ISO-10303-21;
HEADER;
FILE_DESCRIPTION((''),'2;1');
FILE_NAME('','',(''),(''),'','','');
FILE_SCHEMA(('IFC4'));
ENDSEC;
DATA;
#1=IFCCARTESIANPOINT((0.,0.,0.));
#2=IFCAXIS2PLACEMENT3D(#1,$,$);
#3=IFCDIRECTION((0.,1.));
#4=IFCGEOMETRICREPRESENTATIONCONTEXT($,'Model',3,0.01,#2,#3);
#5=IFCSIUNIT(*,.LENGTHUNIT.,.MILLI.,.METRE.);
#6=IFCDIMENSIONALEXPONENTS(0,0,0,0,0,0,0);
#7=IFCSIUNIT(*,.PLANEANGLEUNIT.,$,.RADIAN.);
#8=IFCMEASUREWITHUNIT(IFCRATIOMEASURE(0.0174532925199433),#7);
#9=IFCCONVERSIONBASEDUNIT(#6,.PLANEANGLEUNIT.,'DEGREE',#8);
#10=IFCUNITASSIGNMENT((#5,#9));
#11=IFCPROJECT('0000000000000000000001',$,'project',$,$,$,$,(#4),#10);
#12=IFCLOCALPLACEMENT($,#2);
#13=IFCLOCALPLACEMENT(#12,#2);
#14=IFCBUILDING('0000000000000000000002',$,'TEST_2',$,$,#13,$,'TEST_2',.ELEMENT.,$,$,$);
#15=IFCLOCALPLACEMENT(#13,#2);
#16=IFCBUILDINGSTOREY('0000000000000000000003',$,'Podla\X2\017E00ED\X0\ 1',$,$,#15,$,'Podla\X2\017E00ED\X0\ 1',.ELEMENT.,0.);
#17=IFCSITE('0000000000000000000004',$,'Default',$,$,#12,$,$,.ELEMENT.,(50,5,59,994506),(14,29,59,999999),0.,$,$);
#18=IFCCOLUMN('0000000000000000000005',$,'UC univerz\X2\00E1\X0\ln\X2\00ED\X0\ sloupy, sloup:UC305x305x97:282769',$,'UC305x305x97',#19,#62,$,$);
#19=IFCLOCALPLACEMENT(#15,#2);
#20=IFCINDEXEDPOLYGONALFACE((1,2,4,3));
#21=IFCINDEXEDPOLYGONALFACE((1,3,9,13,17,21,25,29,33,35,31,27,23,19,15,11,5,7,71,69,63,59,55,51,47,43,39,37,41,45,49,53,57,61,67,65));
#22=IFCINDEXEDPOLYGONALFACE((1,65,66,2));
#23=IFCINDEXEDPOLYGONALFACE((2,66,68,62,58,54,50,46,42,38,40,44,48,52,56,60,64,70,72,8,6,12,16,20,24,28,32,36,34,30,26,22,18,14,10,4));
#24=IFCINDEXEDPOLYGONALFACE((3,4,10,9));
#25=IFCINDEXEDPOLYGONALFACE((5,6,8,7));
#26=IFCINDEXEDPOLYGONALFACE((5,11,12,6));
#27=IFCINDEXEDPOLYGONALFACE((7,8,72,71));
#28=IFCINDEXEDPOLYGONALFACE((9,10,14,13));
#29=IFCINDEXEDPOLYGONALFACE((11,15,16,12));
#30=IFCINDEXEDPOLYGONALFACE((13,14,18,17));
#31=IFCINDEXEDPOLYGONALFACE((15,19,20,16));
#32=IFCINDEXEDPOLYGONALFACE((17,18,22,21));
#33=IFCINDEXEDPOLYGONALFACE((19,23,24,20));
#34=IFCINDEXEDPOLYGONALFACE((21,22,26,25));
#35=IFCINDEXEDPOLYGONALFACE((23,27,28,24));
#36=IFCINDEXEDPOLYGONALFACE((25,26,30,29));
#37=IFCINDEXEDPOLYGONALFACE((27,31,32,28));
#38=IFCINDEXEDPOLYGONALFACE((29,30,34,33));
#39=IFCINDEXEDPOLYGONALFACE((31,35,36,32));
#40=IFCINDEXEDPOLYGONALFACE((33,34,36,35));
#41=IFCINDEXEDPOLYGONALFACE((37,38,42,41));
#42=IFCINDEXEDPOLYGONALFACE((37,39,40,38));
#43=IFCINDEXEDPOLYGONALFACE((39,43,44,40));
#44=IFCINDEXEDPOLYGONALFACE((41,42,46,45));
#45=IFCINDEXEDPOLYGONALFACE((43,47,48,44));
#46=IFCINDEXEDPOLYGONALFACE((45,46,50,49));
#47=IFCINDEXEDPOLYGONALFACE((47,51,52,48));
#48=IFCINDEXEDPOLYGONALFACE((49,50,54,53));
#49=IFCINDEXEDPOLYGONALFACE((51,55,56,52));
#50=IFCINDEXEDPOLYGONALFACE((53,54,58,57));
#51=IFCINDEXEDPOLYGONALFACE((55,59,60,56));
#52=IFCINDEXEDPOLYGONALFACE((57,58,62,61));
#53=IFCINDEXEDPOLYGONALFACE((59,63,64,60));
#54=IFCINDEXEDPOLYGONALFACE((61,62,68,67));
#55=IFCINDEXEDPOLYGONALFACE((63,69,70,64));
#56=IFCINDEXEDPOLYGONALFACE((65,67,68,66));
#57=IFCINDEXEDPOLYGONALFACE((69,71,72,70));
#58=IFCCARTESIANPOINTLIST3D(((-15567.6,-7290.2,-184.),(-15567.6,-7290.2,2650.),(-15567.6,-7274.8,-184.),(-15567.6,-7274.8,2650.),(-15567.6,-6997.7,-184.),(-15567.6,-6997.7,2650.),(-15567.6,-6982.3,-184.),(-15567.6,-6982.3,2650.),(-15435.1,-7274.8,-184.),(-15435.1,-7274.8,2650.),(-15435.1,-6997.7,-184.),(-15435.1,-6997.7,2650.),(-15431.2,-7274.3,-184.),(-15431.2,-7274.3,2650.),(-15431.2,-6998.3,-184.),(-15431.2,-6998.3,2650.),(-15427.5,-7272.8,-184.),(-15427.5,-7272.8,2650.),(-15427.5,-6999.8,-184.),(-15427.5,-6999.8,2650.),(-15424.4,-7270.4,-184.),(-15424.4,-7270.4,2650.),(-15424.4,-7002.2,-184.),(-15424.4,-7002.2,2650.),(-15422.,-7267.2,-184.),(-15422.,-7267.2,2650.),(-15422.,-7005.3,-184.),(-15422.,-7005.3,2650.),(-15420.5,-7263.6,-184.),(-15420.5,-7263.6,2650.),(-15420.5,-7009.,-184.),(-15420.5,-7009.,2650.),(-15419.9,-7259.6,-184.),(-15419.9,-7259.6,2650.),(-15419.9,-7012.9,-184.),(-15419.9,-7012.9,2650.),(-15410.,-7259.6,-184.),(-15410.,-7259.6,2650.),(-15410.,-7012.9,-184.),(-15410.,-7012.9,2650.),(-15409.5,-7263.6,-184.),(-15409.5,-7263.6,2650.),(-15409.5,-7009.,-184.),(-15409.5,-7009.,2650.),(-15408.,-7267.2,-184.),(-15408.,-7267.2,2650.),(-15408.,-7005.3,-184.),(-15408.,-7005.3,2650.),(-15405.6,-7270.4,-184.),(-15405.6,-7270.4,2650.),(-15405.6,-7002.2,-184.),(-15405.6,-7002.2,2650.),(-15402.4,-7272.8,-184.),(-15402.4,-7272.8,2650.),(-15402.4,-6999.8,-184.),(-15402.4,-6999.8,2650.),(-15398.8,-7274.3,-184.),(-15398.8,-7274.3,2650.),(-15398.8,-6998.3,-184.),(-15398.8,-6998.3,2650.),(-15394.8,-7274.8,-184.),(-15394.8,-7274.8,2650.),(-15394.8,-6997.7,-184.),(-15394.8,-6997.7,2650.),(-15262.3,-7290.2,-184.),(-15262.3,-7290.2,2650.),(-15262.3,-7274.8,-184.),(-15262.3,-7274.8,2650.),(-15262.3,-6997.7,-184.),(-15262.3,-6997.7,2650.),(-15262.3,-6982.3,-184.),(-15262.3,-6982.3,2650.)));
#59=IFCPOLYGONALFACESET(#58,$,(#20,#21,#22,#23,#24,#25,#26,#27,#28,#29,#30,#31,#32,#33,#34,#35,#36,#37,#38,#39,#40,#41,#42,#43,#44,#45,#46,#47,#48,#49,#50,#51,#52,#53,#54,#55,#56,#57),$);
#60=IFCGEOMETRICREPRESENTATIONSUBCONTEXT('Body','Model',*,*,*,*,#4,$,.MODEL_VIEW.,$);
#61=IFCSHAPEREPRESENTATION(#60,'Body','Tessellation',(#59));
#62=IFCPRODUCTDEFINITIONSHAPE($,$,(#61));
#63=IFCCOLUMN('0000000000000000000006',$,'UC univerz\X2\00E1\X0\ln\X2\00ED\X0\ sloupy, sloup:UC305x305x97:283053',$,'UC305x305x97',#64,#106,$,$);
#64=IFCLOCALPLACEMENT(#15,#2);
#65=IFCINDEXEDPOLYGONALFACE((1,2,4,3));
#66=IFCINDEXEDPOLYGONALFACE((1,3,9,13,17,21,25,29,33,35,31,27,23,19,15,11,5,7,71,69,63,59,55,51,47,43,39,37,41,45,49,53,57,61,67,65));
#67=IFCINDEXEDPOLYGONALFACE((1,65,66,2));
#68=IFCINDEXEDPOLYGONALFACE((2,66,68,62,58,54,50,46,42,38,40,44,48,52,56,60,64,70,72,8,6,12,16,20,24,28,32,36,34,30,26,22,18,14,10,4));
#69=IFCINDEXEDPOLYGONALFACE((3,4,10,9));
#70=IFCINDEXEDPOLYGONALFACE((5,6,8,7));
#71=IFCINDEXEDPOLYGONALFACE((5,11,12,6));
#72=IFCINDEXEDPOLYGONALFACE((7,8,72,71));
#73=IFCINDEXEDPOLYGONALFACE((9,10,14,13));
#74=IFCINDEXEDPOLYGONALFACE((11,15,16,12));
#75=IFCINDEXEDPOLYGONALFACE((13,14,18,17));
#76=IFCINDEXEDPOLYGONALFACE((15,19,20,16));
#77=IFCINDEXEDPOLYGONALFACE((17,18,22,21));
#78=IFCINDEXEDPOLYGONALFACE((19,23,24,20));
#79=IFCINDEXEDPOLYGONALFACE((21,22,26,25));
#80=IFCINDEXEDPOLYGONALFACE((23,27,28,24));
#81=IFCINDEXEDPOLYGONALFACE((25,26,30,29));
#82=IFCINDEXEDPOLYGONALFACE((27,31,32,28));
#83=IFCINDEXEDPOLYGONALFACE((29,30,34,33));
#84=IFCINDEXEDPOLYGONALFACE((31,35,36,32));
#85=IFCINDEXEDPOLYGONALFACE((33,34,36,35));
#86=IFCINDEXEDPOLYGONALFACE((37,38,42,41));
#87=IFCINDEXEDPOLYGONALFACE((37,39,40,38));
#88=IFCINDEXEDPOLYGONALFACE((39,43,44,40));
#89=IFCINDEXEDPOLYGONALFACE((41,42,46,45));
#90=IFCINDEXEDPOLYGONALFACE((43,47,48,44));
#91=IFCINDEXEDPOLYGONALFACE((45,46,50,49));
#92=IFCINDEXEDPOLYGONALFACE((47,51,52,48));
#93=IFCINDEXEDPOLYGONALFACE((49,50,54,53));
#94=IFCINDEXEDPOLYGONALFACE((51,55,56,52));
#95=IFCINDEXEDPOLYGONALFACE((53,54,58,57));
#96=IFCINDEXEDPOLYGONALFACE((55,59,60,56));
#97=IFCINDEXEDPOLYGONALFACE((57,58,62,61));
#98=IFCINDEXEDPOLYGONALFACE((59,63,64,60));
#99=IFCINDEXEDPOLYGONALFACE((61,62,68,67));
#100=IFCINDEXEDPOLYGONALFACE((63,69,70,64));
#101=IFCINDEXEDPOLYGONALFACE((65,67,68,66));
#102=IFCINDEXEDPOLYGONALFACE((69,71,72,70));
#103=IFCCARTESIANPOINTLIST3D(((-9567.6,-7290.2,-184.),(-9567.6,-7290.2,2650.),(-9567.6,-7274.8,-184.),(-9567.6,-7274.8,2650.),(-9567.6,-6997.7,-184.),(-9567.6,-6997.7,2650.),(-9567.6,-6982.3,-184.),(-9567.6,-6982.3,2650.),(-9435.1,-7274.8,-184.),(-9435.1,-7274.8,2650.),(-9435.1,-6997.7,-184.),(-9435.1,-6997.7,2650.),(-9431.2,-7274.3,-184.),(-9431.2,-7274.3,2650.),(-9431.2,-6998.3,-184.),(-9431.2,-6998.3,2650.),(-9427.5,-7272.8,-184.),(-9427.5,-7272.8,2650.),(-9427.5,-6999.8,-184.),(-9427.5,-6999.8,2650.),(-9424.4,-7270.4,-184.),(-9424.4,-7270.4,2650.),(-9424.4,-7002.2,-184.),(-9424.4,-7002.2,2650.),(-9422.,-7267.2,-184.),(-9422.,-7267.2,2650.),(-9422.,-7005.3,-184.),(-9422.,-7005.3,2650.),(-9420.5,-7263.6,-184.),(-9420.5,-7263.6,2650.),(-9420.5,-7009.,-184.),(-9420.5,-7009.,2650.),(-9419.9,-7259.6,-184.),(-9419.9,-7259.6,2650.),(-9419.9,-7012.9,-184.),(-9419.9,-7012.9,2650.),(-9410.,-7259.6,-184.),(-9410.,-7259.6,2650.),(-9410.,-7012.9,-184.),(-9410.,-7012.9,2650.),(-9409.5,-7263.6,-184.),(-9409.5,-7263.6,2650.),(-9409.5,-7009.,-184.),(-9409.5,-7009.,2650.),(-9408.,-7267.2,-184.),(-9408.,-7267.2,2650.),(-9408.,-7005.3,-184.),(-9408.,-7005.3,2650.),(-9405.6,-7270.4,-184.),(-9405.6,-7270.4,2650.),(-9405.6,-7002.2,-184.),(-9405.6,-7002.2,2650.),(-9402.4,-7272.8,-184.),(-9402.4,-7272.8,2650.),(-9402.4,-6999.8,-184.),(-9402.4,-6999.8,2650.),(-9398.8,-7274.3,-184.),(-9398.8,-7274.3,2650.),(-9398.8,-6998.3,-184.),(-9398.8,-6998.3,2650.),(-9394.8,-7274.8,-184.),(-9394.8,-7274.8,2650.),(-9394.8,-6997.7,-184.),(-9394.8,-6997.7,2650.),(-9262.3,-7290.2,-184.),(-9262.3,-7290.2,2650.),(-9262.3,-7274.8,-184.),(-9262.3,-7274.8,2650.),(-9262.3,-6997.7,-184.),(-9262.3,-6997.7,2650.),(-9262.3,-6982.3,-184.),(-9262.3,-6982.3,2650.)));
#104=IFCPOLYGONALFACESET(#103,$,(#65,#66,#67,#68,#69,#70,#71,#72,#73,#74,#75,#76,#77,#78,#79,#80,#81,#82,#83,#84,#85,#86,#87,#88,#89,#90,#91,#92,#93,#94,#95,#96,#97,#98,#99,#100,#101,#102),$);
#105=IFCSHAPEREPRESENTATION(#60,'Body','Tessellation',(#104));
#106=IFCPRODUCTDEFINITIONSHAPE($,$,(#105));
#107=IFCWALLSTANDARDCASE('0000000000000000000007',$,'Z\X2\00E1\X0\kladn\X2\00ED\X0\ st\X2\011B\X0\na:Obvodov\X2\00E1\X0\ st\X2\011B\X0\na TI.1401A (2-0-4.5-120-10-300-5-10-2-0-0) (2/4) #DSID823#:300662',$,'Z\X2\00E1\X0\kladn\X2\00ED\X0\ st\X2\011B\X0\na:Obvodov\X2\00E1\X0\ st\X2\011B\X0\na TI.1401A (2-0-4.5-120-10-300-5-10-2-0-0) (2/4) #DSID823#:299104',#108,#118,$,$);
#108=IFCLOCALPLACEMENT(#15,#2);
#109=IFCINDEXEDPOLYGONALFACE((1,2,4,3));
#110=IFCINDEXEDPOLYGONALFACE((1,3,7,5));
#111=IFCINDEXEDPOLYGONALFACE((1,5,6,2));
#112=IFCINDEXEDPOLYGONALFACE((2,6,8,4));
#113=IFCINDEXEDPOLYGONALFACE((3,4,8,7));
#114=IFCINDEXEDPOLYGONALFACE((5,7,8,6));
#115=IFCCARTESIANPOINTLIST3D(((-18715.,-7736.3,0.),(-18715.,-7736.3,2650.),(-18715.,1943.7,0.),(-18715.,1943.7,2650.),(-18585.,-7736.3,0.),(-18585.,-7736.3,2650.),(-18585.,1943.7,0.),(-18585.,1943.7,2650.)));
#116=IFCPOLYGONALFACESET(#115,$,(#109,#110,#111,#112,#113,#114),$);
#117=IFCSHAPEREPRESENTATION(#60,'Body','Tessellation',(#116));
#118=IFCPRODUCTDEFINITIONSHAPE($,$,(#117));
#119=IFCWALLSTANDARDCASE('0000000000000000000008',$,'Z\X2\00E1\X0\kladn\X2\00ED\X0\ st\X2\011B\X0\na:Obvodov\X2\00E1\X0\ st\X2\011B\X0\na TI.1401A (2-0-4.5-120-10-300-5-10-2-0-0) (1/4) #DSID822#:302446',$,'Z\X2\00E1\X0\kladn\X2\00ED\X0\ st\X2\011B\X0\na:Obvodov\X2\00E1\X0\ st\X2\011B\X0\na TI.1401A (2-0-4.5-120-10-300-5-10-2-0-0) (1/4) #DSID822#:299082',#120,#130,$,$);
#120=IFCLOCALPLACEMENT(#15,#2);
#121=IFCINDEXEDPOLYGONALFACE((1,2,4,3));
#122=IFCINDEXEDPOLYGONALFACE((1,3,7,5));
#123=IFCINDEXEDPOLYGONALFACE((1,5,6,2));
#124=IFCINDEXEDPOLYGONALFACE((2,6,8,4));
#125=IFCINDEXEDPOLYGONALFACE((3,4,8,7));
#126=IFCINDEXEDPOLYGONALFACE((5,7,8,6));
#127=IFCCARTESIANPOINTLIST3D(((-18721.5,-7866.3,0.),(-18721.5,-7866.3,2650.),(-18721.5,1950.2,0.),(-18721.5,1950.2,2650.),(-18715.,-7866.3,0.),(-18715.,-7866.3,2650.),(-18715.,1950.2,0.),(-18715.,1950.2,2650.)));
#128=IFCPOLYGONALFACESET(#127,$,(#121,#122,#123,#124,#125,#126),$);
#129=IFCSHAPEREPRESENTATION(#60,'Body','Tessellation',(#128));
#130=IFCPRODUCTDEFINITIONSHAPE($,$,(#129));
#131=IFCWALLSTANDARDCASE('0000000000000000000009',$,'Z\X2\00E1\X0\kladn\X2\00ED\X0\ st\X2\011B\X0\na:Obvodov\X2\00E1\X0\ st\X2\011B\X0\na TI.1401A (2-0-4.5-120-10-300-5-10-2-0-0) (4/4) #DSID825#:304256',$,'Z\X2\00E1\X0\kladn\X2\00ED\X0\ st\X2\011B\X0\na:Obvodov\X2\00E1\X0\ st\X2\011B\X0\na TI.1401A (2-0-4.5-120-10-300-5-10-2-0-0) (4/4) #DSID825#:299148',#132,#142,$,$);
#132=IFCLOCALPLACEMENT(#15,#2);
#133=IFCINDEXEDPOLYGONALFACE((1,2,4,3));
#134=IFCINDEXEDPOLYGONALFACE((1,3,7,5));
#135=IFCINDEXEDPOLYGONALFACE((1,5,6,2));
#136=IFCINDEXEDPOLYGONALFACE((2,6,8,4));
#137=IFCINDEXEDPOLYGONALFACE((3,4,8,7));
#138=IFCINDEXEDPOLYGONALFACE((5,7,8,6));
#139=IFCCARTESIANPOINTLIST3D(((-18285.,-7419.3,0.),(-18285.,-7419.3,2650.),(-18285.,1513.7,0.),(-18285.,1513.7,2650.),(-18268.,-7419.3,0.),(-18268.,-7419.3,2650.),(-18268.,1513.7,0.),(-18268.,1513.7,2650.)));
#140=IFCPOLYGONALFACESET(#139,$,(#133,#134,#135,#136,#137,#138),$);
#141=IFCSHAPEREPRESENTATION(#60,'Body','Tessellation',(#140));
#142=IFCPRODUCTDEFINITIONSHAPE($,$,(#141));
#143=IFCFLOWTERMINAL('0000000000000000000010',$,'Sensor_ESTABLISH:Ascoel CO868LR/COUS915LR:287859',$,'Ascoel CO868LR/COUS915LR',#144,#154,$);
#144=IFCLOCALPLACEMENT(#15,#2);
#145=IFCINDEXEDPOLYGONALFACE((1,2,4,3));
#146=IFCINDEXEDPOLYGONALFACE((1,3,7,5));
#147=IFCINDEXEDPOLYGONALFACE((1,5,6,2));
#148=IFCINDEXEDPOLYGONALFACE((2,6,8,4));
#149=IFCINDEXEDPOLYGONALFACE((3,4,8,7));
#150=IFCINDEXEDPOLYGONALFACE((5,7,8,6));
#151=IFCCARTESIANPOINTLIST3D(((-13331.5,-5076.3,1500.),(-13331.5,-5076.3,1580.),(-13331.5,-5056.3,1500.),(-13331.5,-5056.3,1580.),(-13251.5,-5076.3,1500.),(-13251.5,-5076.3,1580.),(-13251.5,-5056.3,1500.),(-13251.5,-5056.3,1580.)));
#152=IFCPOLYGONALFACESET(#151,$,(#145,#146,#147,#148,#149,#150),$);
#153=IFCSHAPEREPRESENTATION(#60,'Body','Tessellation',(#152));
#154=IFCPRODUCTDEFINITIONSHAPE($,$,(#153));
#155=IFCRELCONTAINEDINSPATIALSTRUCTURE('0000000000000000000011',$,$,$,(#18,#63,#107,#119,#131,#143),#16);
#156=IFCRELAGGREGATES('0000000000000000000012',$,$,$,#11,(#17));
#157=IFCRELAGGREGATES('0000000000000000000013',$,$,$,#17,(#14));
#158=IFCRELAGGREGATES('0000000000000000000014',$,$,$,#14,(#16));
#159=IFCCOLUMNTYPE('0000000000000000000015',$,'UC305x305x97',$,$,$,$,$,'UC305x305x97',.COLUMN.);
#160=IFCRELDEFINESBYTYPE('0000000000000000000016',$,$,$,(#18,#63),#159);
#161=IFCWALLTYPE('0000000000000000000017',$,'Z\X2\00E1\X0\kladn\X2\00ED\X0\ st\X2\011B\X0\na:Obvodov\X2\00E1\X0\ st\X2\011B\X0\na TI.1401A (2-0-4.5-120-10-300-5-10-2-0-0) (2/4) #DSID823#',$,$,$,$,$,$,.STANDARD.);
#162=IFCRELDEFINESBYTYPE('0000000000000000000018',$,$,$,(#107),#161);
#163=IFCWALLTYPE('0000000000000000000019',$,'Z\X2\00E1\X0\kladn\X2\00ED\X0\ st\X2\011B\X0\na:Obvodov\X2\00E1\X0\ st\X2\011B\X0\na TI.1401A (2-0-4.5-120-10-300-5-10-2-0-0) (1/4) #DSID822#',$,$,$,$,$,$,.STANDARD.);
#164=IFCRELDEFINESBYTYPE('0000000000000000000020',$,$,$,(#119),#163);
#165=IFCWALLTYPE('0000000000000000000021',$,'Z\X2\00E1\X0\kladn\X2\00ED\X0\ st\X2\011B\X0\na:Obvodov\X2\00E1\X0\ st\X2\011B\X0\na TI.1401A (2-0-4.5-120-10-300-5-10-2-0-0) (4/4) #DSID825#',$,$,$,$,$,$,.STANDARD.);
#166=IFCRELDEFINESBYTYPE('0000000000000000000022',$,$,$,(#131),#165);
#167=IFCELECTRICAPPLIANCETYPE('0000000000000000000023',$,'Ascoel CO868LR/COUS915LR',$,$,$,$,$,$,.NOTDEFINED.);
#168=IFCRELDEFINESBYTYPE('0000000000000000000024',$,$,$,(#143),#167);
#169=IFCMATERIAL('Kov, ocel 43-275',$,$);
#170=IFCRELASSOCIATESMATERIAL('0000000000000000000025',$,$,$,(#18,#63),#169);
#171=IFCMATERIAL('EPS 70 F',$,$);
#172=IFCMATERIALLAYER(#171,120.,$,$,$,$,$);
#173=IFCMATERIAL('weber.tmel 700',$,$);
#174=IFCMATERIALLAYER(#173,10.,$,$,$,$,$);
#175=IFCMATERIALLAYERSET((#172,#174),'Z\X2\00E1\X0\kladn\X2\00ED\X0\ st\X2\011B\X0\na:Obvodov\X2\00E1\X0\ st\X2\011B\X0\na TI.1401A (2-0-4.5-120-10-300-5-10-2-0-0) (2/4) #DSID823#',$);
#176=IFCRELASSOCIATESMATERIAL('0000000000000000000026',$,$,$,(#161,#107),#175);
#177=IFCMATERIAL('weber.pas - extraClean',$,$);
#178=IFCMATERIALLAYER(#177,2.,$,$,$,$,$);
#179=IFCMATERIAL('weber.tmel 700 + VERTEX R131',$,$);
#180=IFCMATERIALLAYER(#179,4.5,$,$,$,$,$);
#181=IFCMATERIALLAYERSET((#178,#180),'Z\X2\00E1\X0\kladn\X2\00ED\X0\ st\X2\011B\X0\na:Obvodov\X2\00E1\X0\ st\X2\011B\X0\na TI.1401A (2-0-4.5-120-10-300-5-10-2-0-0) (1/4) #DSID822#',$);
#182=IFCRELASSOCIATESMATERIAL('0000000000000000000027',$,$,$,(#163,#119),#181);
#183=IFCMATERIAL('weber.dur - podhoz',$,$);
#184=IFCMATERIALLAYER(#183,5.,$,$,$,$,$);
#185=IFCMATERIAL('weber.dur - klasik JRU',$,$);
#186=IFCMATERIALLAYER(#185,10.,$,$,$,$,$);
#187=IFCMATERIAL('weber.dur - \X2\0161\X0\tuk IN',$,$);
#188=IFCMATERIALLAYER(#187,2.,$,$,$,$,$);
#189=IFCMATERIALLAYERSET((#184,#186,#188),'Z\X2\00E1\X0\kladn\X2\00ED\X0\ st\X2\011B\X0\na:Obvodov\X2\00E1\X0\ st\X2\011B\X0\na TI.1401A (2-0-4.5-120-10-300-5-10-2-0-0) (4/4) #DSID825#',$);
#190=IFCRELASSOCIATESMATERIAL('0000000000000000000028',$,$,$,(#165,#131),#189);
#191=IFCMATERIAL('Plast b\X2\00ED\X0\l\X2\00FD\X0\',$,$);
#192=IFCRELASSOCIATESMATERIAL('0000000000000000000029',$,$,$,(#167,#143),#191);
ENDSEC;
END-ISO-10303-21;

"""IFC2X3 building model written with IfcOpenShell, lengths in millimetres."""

from ifc_helpers import new_model, entity, si_unit, converted_unit, direction, frame, frame_2d, origin, origin_2d_with_axis, place, context, subcontext, project, spatial, rectangle, i_section, extrude, source, transform, mapped, material, layer, layer_set, layer_usage, type_object, type_shapes, element, save


model = new_model("IFC2X3")

# Units and contexts
model_context = context("Model", 3, precision=0.01, world=origin(), true_north=direction((0.0, 1.0)))
body_context = subcontext(model_context, "Body", "Model", "MODEL_VIEW")
ifc_project = project(units=[si_unit("LENGTHUNIT", "METRE", prefix="MILLI"), converted_unit("PLANEANGLEUNIT", "DEGREE", entity("IfcRatioMeasure", 0.0174532925199433), si_unit("PLANEANGLEUNIT", "RADIAN"), dimensions=[0, 0, 0, 0, 0, 0, 0])], contexts=[model_context])

# Site, building, storey
site_placement = place(None, origin())
site = spatial("IfcSite", under=ifc_project, at=site_placement, Name="Default", CompositionType="ELEMENT", RefLatitude=(50, 5, 59, 994506), RefLongitude=(14, 29, 59, 999999), RefElevation=0.0)
building_placement = place(site_placement, origin())
building = spatial("IfcBuilding", under=site, at=building_placement, Name="TEST_2", LongName="TEST_2", CompositionType="ELEMENT")
storey_placement = place(building_placement, origin())
storey = spatial("IfcBuildingStorey", under=building, at=storey_placement, Name="Podlaží 1", LongName="Podlaží 1", CompositionType="ELEMENT", Elevation=0.0)

# Columns
ifc_material_1 = material(Name="Kov, ocel 43-275")
column_type = type_object("IfcColumnType", Name="UC305x305x97", ElementType="UC305x305x97", PredefinedType="COLUMN")
shared_shape_1 = source(origin(), body_context, "Body", "SweptSolid", [
    extrude(i_section(OverallWidth=305.3, OverallDepth=307.9, WebThickness=9.9, FlangeThickness=15.4, FilletRadius=15.2, at=origin_2d_with_axis()), frame((0.0, 0.0, -184.0), z_axis=(0.0, 0.0, 1.0), x_axis=(-1.0, 0.0, 0.0)), (0.0, 0.0, 1.0), 2834.0),
])
type_shapes(column_type, [shared_shape_1])
for number, where, name in (
    (1, (-15415.0, -7136.3, 0.0), "UC univerzální sloupy, sloup:UC305x305x97:282769"),
    (2, (-9415.0, -7136.3, 0.0), "UC univerzální sloupy, sloup:UC305x305x97:283053"),
):
    element("IfcColumn", number, at=place(storey_placement, frame(where)), inside=storey, type_object=column_type, material=ifc_material_1, Name=name, ObjectType="UC305x305x97", context=body_context, shape_type="MappedRepresentation", body=[
        mapped(shared_shape_1, transform((0.0, 0.0, 0.0), scale=1.0)),
    ])

# Walls
ifc_material_2 = material(Name="EPS 70 F")
ifc_layer_1 = layer(ifc_material_2, 120.0)
ifc_material_3 = material(Name="weber.tmel 700")
ifc_layer_2 = layer(ifc_material_3, 10.0)
ifc_layer_set_1 = layer_set([ifc_layer_1, ifc_layer_2], Name="Základní stěna:Obvodová stěna TI.1401A (2-0-4.5-120-10-300-5-10-2-0-0) (2/4) #DSID823#")
ifc_layer_usage_1 = layer_usage(ifc_layer_set_1, "AXIS2", "NEGATIVE", 65.0)
wall_type_1 = type_object("IfcWallType", Name="Základní stěna:Obvodová stěna TI.1401A (2-0-4.5-120-10-300-5-10-2-0-0) (2/4) #DSID823#", PredefinedType="STANDARD", material=ifc_layer_set_1)
wall_1_placement = place(storey_placement, frame((-18650.0, -7736.3, 0.0), z_axis=(0.0, 0.0, 1.0), x_axis=(0.0, 1.0, 0.0)))
element("IfcWallStandardCase", 3, at=wall_1_placement, inside=storey, type_object=wall_type_1, material=ifc_layer_usage_1, Name="Základní stěna:Obvodová stěna TI.1401A (2-0-4.5-120-10-300-5-10-2-0-0) (2/4) #DSID823#:300662", ObjectType="Základní stěna:Obvodová stěna TI.1401A (2-0-4.5-120-10-300-5-10-2-0-0) (2/4) #DSID823#:299104", context=body_context, shape_type="SweptSolid", body=[
    extrude(rectangle(XDim=9680.0, YDim=130.0, at=frame_2d((4840.0, 0.0), x_axis=(-1.0, 0.0))), origin(), (0.0, 0.0, 1.0), 2650.0),
])
ifc_material_4 = material(Name="weber.pas - extraClean")
ifc_layer_3 = layer(ifc_material_4, 2.0)
ifc_material_5 = material(Name="weber.tmel 700 + VERTEX R131")
ifc_layer_4 = layer(ifc_material_5, 4.5)
ifc_layer_set_2 = layer_set([ifc_layer_3, ifc_layer_4], Name="Základní stěna:Obvodová stěna TI.1401A (2-0-4.5-120-10-300-5-10-2-0-0) (1/4) #DSID822#")
ifc_layer_usage_2 = layer_usage(ifc_layer_set_2, "AXIS2", "NEGATIVE", 3.2)
wall_type_2 = type_object("IfcWallType", Name="Základní stěna:Obvodová stěna TI.1401A (2-0-4.5-120-10-300-5-10-2-0-0) (1/4) #DSID822#", PredefinedType="STANDARD", material=ifc_layer_set_2)
wall_2_placement = place(storey_placement, frame((-18718.2, -7866.3, 0.0), z_axis=(0.0, 0.0, 1.0), x_axis=(0.0, 1.0, 0.0)))
element("IfcWallStandardCase", 4, at=wall_2_placement, inside=storey, type_object=wall_type_2, material=ifc_layer_usage_2, Name="Základní stěna:Obvodová stěna TI.1401A (2-0-4.5-120-10-300-5-10-2-0-0) (1/4) #DSID822#:302446", ObjectType="Základní stěna:Obvodová stěna TI.1401A (2-0-4.5-120-10-300-5-10-2-0-0) (1/4) #DSID822#:299082", context=body_context, shape_type="SweptSolid", body=[
    extrude(rectangle(XDim=9816.5, YDim=6.5, at=frame_2d((4908.2, 0.0), x_axis=(-1.0, 0.0))), origin(), (0.0, 0.0, 1.0), 2650.0),
])
ifc_material_6 = material(Name="weber.dur - podhoz")
ifc_layer_5 = layer(ifc_material_6, 5.0)
ifc_material_7 = material(Name="weber.dur - klasik JRU")
ifc_layer_6 = layer(ifc_material_7, 10.0)
ifc_material_8 = material(Name="weber.dur - štuk IN")
ifc_layer_7 = layer(ifc_material_8, 2.0)
ifc_layer_set_3 = layer_set([ifc_layer_5, ifc_layer_6, ifc_layer_7], Name="Základní stěna:Obvodová stěna TI.1401A (2-0-4.5-120-10-300-5-10-2-0-0) (4/4) #DSID825#")
ifc_layer_usage_3 = layer_usage(ifc_layer_set_3, "AXIS2", "POSITIVE", -8.5)
wall_type_3 = type_object("IfcWallType", Name="Základní stěna:Obvodová stěna TI.1401A (2-0-4.5-120-10-300-5-10-2-0-0) (4/4) #DSID825#", PredefinedType="STANDARD", material=ifc_layer_set_3)
wall_3_placement = place(storey_placement, frame((-18276.5, -7419.3, 0.0), z_axis=(0.0, 0.0, 1.0), x_axis=(0.0, 1.0, 0.0)))
element("IfcWallStandardCase", 5, at=wall_3_placement, inside=storey, type_object=wall_type_3, material=ifc_layer_usage_3, Name="Základní stěna:Obvodová stěna TI.1401A (2-0-4.5-120-10-300-5-10-2-0-0) (4/4) #DSID825#:304256", ObjectType="Základní stěna:Obvodová stěna TI.1401A (2-0-4.5-120-10-300-5-10-2-0-0) (4/4) #DSID825#:299148", context=body_context, shape_type="SweptSolid", body=[
    extrude(rectangle(XDim=8933.0, YDim=17.0, at=frame_2d((4466.5, 0.0), x_axis=(-1.0, 0.0))), origin(), (0.0, 0.0, 1.0), 2650.0),
])

# Flow terminal
ifc_material_9 = material(Name="Plast bílý")
electric_appliance_type_1 = type_object("IfcElectricApplianceType", Name="Ascoel CO868LR/COUS915LR", PredefinedType="NOTDEFINED", material=ifc_material_9)
shared_shape_2 = source(origin(), body_context, "Body", "SweptSolid", [
    extrude(rectangle(XDim=80.0, YDim=20.0, at=origin_2d_with_axis()), frame((0.0, 0.0, 0.0), z_axis=(0.0, 0.0, 1.0), x_axis=(-1.0, 0.0, 0.0)), (0.0, 0.0, 1.0), 80.0),
])
type_shapes(electric_appliance_type_1, [shared_shape_2])
flow_terminal_1_placement = place(storey_placement, frame((-13291.5, -5066.3, 1500.0)))
element("IfcFlowTerminal", 6, at=flow_terminal_1_placement, inside=storey, type_object=electric_appliance_type_1, material=ifc_material_9, Name="Sensor_ESTABLISH:Ascoel CO868LR/COUS915LR:287859", ObjectType="Ascoel CO868LR/COUS915LR", context=body_context, shape_type="MappedRepresentation", body=[
    mapped(shared_shape_2, transform((0.0, 0.0, 0.0), scale=1.0)),
])

save(model, "model.ifc")
